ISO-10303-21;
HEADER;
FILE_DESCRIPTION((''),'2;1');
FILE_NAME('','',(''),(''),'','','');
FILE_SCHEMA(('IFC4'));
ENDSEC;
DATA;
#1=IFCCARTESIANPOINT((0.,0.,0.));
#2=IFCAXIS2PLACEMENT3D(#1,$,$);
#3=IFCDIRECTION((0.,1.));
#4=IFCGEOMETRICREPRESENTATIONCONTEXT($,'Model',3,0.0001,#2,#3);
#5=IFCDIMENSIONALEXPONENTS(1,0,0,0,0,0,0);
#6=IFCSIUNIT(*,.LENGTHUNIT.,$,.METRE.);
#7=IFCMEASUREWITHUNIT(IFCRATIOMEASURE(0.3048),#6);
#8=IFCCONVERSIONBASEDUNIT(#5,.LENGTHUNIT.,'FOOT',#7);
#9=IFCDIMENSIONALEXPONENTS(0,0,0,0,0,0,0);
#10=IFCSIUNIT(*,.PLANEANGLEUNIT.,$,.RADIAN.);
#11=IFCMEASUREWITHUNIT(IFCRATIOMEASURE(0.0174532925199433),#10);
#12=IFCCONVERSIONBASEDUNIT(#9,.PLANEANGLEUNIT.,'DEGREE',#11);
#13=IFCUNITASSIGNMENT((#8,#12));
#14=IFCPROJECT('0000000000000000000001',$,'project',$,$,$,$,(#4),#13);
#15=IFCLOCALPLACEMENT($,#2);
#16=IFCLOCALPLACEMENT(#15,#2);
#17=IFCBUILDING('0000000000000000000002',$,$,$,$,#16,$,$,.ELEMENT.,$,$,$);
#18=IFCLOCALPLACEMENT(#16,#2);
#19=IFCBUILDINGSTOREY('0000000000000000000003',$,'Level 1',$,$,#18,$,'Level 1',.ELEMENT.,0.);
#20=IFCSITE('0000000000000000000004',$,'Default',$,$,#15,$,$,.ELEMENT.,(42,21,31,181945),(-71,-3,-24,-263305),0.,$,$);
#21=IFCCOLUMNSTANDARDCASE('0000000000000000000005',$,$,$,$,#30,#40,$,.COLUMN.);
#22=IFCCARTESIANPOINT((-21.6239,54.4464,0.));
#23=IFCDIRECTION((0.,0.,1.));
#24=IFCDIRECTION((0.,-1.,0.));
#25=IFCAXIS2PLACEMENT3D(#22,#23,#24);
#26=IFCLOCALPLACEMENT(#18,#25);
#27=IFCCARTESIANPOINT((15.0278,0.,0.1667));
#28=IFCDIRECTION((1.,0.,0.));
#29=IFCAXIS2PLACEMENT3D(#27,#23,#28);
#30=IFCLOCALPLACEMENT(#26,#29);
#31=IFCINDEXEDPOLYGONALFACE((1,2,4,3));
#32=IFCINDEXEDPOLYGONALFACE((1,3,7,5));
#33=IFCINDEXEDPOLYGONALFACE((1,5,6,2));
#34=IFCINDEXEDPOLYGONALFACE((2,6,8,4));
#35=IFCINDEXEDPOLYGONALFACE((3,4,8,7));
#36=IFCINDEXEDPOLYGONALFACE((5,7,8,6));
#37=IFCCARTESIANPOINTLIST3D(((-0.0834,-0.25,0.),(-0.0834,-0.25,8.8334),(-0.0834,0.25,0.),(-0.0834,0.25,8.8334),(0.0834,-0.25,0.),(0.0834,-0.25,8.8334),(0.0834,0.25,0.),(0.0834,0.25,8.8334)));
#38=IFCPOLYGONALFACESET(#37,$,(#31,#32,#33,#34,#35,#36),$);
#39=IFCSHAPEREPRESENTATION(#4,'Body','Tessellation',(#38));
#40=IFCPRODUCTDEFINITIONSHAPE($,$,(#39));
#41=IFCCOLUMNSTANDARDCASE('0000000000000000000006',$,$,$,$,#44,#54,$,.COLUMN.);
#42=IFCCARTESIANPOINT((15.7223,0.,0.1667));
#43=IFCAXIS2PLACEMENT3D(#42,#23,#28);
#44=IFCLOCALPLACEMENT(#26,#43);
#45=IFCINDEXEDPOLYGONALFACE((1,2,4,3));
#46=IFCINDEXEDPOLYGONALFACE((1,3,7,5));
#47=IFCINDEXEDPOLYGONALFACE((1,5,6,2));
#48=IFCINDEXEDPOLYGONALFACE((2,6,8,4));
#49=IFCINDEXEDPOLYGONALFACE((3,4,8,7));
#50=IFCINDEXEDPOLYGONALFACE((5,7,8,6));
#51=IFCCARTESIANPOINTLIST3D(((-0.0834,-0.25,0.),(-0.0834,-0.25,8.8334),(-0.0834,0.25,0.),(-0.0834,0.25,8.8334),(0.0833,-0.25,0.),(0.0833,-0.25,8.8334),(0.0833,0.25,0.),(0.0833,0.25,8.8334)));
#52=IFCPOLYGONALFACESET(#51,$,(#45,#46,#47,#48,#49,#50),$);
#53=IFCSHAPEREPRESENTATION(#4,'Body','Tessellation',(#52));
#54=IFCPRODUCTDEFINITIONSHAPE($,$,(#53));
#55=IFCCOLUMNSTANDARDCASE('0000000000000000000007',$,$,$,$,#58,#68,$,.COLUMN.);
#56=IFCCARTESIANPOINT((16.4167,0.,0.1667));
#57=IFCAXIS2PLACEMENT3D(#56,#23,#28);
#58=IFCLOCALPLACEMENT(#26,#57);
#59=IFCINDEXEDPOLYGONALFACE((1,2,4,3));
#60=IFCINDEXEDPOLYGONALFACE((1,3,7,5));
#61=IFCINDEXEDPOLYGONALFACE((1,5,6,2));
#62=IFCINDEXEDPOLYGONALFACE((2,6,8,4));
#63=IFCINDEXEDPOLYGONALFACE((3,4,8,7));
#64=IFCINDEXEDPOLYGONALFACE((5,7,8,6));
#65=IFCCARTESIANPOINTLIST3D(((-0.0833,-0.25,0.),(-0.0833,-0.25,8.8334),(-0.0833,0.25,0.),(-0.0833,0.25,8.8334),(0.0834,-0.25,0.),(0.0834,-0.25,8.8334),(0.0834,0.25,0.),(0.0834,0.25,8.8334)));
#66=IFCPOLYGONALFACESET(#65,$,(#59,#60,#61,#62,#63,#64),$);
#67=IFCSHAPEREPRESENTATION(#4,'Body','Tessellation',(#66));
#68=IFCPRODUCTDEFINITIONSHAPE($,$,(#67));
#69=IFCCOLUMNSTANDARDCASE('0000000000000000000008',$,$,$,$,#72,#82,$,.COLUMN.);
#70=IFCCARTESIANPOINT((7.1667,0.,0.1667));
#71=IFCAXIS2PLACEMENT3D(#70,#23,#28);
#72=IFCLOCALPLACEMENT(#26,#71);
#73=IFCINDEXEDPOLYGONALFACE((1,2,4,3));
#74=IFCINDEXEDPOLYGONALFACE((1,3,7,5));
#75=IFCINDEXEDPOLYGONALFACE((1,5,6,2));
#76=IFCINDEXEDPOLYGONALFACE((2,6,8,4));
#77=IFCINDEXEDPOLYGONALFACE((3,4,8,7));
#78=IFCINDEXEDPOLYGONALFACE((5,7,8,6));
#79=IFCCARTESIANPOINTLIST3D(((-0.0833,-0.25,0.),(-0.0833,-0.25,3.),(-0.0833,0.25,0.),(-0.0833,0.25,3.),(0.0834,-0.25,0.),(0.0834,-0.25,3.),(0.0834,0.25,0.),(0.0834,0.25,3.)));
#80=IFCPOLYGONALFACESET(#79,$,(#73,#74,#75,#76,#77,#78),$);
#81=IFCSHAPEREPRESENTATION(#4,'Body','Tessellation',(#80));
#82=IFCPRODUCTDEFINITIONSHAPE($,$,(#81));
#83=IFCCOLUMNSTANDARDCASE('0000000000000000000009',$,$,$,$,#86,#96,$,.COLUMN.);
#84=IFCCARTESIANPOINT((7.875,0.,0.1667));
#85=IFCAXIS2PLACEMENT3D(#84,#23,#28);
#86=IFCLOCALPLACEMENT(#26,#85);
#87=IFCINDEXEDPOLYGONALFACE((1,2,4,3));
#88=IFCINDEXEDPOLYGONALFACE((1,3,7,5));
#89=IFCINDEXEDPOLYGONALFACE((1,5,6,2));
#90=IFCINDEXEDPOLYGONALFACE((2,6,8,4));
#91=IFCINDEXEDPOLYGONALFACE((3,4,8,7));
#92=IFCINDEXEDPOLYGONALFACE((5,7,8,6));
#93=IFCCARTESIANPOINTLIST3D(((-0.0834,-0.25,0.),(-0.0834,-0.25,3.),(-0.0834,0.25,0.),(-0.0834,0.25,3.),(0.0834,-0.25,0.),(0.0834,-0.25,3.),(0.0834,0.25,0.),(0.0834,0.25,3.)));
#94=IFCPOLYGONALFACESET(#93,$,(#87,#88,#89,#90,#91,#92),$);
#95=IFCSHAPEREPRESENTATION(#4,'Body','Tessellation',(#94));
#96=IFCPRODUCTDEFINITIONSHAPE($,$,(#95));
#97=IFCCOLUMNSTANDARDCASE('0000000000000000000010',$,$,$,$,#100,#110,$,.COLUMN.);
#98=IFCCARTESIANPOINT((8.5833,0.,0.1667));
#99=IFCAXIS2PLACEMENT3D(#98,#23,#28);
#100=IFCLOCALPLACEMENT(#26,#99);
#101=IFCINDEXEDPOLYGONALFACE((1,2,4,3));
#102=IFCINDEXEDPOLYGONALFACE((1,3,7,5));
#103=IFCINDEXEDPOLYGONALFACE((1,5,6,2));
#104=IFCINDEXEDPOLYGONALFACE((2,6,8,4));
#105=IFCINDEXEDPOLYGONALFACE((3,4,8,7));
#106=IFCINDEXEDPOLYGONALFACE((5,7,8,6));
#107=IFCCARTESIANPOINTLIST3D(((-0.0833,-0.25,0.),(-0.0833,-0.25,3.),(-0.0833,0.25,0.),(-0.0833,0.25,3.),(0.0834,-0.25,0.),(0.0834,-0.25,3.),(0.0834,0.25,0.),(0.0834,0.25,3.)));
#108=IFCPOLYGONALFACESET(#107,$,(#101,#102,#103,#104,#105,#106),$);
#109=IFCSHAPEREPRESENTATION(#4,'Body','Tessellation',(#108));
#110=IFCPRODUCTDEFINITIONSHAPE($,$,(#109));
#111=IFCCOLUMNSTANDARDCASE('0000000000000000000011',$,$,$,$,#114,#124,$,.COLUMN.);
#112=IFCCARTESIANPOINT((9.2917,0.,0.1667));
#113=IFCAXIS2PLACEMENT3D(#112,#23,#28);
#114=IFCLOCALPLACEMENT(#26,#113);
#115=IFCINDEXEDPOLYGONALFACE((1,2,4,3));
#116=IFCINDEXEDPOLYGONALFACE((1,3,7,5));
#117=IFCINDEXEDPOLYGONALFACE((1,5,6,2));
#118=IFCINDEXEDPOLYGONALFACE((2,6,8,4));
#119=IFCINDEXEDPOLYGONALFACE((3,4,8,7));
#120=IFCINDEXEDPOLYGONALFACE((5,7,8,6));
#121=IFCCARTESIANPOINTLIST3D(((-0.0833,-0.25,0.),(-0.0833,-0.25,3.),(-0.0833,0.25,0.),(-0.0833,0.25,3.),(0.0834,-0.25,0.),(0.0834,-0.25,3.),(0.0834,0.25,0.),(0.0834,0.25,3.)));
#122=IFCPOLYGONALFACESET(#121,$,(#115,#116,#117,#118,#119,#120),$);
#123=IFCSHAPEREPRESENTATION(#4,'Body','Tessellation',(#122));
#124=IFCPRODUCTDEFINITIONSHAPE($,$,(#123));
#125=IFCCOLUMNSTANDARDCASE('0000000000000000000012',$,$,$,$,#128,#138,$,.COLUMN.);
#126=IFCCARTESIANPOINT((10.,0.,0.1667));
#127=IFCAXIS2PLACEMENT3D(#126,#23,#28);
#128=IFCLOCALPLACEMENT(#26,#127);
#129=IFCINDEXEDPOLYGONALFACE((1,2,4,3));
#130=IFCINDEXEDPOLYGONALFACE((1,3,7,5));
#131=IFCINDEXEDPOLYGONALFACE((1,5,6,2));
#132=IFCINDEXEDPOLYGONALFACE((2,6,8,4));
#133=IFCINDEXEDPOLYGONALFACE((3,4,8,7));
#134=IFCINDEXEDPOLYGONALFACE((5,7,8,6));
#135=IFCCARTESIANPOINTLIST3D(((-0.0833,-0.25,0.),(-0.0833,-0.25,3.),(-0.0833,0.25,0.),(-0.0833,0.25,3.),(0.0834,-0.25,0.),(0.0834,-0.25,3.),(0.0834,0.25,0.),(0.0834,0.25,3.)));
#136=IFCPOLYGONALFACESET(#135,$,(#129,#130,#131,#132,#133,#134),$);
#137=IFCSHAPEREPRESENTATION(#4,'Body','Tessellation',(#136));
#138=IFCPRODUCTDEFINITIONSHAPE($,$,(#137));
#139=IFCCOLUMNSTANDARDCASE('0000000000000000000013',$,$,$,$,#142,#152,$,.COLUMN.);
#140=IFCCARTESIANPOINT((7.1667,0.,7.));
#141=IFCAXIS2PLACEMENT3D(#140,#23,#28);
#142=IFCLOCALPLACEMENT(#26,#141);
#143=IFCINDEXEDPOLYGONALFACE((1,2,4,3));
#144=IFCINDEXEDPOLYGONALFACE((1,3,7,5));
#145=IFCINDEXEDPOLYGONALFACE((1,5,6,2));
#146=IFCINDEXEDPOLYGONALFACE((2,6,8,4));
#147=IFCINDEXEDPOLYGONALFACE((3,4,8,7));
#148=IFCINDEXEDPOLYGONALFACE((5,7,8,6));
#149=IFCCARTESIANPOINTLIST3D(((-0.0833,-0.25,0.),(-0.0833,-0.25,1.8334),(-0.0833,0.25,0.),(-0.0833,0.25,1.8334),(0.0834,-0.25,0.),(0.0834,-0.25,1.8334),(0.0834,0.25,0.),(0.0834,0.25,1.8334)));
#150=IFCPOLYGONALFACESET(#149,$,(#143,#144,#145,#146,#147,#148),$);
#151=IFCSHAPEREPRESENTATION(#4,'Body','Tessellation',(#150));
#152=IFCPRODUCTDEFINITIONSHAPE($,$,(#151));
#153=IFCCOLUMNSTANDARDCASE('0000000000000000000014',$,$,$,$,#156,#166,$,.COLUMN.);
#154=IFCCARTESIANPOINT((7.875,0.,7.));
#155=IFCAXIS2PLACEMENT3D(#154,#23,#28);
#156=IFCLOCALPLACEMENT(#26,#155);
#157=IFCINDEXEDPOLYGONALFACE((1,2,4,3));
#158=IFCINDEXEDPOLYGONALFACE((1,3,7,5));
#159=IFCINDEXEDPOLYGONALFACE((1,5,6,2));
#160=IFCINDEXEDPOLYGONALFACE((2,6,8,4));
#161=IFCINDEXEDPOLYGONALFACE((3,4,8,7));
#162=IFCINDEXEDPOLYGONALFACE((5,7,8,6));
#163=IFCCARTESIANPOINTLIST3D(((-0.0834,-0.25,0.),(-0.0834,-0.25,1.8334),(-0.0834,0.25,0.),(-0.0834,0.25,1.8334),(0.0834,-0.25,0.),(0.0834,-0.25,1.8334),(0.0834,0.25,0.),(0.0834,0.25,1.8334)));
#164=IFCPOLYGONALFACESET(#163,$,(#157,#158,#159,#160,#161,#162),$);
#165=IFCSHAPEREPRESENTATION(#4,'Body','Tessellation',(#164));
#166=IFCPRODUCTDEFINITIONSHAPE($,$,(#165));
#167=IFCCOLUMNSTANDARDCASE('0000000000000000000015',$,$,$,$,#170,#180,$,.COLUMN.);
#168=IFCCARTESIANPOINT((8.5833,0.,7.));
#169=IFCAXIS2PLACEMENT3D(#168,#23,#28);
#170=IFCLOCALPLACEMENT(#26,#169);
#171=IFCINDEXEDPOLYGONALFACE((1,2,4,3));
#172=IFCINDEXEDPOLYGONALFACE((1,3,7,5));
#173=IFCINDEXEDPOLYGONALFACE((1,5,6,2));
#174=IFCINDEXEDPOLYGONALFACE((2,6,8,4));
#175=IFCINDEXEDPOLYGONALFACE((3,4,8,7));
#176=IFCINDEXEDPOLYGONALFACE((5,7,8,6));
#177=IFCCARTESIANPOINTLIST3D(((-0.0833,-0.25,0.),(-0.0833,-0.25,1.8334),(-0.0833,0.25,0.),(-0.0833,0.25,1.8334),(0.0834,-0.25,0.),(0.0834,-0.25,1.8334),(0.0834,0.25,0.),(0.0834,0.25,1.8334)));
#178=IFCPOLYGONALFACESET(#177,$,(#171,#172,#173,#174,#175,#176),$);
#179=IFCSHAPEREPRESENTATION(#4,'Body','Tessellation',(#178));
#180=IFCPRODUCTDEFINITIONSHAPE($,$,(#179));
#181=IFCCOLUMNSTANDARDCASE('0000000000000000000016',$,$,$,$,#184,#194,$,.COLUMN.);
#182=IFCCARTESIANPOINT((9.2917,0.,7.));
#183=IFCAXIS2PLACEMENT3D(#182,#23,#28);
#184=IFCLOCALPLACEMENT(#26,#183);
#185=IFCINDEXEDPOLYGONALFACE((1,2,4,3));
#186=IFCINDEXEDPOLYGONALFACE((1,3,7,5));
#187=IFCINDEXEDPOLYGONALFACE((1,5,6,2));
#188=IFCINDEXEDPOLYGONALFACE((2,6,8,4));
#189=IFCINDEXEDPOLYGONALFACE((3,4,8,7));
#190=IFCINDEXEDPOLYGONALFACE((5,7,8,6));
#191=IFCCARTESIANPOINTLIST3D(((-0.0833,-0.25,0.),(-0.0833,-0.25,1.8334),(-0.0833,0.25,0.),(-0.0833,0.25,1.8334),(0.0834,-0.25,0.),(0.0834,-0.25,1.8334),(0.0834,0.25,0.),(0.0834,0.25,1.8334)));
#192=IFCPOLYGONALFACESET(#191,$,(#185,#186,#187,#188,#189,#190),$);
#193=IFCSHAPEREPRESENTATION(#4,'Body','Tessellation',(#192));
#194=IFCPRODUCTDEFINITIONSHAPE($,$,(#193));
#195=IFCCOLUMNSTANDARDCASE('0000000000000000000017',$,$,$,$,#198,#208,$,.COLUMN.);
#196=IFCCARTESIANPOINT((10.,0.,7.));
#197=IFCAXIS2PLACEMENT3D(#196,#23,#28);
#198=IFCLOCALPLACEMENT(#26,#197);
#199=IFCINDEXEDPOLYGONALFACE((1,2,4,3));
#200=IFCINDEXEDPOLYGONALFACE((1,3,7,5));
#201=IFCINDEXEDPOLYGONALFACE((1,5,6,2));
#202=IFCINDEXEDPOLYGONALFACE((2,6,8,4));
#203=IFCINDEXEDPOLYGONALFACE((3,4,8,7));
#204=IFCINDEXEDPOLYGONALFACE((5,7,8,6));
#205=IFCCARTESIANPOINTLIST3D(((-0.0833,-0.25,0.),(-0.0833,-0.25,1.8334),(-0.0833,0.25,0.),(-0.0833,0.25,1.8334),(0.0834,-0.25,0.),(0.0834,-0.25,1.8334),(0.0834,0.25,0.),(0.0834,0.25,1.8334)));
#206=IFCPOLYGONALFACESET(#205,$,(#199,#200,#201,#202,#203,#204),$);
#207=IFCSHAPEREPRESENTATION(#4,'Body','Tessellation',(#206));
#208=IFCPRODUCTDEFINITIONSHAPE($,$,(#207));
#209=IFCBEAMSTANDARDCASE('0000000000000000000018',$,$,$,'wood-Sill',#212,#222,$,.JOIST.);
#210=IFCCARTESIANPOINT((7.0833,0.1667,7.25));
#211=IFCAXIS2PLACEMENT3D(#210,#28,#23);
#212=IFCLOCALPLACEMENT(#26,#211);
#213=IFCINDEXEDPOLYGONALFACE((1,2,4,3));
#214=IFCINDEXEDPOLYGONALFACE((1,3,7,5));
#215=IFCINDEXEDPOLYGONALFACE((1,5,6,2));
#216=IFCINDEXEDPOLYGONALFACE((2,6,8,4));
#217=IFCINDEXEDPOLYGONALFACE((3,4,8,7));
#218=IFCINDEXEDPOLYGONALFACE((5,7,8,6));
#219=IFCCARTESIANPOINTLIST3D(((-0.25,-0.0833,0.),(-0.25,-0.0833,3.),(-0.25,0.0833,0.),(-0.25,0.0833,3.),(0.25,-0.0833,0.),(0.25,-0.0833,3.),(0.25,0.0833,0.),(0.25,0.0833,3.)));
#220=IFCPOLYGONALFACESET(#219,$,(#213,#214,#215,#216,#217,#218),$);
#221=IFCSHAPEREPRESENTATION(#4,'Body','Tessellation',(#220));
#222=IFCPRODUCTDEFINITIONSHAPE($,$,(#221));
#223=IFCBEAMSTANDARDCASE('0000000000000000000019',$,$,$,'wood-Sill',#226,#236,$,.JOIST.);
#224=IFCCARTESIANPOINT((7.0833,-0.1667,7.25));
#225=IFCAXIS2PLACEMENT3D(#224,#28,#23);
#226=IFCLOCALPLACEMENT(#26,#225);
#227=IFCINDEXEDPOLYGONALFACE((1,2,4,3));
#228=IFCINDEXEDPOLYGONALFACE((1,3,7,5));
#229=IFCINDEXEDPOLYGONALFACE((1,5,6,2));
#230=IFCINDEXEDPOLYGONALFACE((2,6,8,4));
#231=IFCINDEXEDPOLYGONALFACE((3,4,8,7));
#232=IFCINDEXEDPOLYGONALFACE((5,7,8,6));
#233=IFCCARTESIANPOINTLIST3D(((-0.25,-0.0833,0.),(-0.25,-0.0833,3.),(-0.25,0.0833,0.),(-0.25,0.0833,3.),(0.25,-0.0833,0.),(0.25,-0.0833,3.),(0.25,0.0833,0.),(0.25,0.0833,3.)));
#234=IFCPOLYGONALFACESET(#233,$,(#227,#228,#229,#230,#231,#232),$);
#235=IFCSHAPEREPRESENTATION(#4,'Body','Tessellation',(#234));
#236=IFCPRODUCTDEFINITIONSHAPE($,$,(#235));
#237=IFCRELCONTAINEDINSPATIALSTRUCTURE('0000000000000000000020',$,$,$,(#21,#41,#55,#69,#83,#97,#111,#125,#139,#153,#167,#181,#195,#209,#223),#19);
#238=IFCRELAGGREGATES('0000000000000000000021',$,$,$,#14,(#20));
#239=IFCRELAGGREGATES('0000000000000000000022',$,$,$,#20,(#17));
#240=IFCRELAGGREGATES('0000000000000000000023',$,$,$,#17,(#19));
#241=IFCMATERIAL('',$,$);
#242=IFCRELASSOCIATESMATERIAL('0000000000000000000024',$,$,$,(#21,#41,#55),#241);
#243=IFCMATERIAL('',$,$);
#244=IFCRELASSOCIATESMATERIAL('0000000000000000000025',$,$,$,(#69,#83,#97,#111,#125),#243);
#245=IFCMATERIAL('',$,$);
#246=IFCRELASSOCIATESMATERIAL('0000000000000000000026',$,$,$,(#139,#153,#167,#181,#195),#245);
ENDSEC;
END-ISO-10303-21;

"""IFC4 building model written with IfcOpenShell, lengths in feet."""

from ifc_helpers import new_model, entity, si_unit, converted_unit, direction, frame, origin, origin_with_axes, place, context, project, spatial, rectangle, extrude, material, element, save


model = new_model("IFC4")

# Units and contexts
model_context = context("Model", 3, precision=0.0001, world=origin(), true_north=direction((0.0, 1.0)))
ifc_project = project(units=[converted_unit("LENGTHUNIT", "FOOT", entity("IfcRatioMeasure", 0.3048), si_unit("LENGTHUNIT", "METRE"), dimensions=[1, 0, 0, 0, 0, 0, 0]), converted_unit("PLANEANGLEUNIT", "DEGREE", entity("IfcRatioMeasure", 0.0174532925199433), si_unit("PLANEANGLEUNIT", "RADIAN"), dimensions=[0, 0, 0, 0, 0, 0, 0])], contexts=[model_context])

# Site, building, storey
site_placement = place(None, origin())
site = spatial("IfcSite", under=ifc_project, at=site_placement, Name="Default", CompositionType="ELEMENT", RefLatitude=(42, 21, 31, 181945), RefLongitude=(-71, -3, -24, -263305), RefElevation=0.0)
building_placement = place(site_placement, origin())
building = spatial("IfcBuilding", under=site, at=building_placement, CompositionType="ELEMENT")
storey_placement = place(building_placement, origin())
storey = spatial("IfcBuildingStorey", under=building, at=storey_placement, Name="Level 1", LongName="Level 1", CompositionType="ELEMENT", Elevation=0.0)

# Columns
placement_1 = place(storey_placement, frame((-21.6239, 54.4464, 0.0), z_axis=(0.0, 0.0, 1.0), x_axis=(0.0, -1.0, 0.0)))
ifc_material_1 = material(Name="")
for number, where, z_axis, x_axis in (
    (1, (15.0278, 0.0, 0.1667), (0.0, 0.0, 1.0), (1.0, 0.0, 0.0)),
    (2, (15.7223, 0.0, 0.1667), (0.0, 0.0, 1.0), (1.0, 0.0, 0.0)),
    (3, (16.4167, 0.0, 0.1667), (0.0, 0.0, 1.0), (1.0, 0.0, 0.0)),
):
    element("IfcColumnStandardCase", number, at=place(placement_1, frame(where, z_axis=z_axis, x_axis=x_axis)), inside=storey, material=ifc_material_1, PredefinedType="COLUMN", context=model_context, shape_type="SweptSolid", body=[
        extrude(rectangle(XDim=0.1667, YDim=0.5), origin(), (0.0, 0.0, 1.0), 8.8334),
    ])
ifc_material_2 = material(Name="")
for number, where, z_axis, x_axis in (
    (4, (7.1667, 0.0, 0.1667), (0.0, 0.0, 1.0), (1.0, 0.0, 0.0)),
    (5, (7.875, 0.0, 0.1667), (0.0, 0.0, 1.0), (1.0, 0.0, 0.0)),
    (6, (8.5833, 0.0, 0.1667), (0.0, 0.0, 1.0), (1.0, 0.0, 0.0)),
    (7, (9.2917, 0.0, 0.1667), (0.0, 0.0, 1.0), (1.0, 0.0, 0.0)),
    (8, (10.0, 0.0, 0.1667), (0.0, 0.0, 1.0), (1.0, 0.0, 0.0)),
):
    element("IfcColumnStandardCase", number, at=place(placement_1, frame(where, z_axis=z_axis, x_axis=x_axis)), inside=storey, material=ifc_material_2, PredefinedType="COLUMN", context=model_context, shape_type="SweptSolid", body=[
        extrude(rectangle(XDim=0.1667, YDim=0.5), origin(), (0.0, 0.0, 1.0), 3.0),
    ])
ifc_material_3 = material(Name="")
for number, where, z_axis, x_axis in (
    (9, (7.1667, 0.0, 7.0), (0.0, 0.0, 1.0), (1.0, 0.0, 0.0)),
    (10, (7.875, 0.0, 7.0), (0.0, 0.0, 1.0), (1.0, 0.0, 0.0)),
    (11, (8.5833, 0.0, 7.0), (0.0, 0.0, 1.0), (1.0, 0.0, 0.0)),
    (12, (9.2917, 0.0, 7.0), (0.0, 0.0, 1.0), (1.0, 0.0, 0.0)),
    (13, (10.0, 0.0, 7.0), (0.0, 0.0, 1.0), (1.0, 0.0, 0.0)),
):
    element("IfcColumnStandardCase", number, at=place(placement_1, frame(where, z_axis=z_axis, x_axis=x_axis)), inside=storey, material=ifc_material_3, PredefinedType="COLUMN", context=model_context, shape_type="SweptSolid", body=[
        extrude(rectangle(XDim=0.1667, YDim=0.5), origin(), (0.0, 0.0, 1.0), 1.8334),
    ])

# Beams
for number, where, z_axis, x_axis in (
    (14, (7.0833, 0.1667, 7.25), (1.0, 0.0, 0.0), (0.0, 0.0, 1.0)),
    (15, (7.0833, -0.1667, 7.25), (1.0, 0.0, 0.0), (0.0, 0.0, 1.0)),
):
    element("IfcBeamStandardCase", number, at=place(placement_1, frame(where, z_axis=z_axis, x_axis=x_axis)), inside=storey, ObjectType="wood-Sill", PredefinedType="JOIST", context=model_context, shape_type="SweptSolid", body=[
        extrude(rectangle(XDim=0.5, YDim=0.1667), origin_with_axes(), (0.0, 0.0, 1.0), 3.0),
    ])

save(model, "model.ifc")
